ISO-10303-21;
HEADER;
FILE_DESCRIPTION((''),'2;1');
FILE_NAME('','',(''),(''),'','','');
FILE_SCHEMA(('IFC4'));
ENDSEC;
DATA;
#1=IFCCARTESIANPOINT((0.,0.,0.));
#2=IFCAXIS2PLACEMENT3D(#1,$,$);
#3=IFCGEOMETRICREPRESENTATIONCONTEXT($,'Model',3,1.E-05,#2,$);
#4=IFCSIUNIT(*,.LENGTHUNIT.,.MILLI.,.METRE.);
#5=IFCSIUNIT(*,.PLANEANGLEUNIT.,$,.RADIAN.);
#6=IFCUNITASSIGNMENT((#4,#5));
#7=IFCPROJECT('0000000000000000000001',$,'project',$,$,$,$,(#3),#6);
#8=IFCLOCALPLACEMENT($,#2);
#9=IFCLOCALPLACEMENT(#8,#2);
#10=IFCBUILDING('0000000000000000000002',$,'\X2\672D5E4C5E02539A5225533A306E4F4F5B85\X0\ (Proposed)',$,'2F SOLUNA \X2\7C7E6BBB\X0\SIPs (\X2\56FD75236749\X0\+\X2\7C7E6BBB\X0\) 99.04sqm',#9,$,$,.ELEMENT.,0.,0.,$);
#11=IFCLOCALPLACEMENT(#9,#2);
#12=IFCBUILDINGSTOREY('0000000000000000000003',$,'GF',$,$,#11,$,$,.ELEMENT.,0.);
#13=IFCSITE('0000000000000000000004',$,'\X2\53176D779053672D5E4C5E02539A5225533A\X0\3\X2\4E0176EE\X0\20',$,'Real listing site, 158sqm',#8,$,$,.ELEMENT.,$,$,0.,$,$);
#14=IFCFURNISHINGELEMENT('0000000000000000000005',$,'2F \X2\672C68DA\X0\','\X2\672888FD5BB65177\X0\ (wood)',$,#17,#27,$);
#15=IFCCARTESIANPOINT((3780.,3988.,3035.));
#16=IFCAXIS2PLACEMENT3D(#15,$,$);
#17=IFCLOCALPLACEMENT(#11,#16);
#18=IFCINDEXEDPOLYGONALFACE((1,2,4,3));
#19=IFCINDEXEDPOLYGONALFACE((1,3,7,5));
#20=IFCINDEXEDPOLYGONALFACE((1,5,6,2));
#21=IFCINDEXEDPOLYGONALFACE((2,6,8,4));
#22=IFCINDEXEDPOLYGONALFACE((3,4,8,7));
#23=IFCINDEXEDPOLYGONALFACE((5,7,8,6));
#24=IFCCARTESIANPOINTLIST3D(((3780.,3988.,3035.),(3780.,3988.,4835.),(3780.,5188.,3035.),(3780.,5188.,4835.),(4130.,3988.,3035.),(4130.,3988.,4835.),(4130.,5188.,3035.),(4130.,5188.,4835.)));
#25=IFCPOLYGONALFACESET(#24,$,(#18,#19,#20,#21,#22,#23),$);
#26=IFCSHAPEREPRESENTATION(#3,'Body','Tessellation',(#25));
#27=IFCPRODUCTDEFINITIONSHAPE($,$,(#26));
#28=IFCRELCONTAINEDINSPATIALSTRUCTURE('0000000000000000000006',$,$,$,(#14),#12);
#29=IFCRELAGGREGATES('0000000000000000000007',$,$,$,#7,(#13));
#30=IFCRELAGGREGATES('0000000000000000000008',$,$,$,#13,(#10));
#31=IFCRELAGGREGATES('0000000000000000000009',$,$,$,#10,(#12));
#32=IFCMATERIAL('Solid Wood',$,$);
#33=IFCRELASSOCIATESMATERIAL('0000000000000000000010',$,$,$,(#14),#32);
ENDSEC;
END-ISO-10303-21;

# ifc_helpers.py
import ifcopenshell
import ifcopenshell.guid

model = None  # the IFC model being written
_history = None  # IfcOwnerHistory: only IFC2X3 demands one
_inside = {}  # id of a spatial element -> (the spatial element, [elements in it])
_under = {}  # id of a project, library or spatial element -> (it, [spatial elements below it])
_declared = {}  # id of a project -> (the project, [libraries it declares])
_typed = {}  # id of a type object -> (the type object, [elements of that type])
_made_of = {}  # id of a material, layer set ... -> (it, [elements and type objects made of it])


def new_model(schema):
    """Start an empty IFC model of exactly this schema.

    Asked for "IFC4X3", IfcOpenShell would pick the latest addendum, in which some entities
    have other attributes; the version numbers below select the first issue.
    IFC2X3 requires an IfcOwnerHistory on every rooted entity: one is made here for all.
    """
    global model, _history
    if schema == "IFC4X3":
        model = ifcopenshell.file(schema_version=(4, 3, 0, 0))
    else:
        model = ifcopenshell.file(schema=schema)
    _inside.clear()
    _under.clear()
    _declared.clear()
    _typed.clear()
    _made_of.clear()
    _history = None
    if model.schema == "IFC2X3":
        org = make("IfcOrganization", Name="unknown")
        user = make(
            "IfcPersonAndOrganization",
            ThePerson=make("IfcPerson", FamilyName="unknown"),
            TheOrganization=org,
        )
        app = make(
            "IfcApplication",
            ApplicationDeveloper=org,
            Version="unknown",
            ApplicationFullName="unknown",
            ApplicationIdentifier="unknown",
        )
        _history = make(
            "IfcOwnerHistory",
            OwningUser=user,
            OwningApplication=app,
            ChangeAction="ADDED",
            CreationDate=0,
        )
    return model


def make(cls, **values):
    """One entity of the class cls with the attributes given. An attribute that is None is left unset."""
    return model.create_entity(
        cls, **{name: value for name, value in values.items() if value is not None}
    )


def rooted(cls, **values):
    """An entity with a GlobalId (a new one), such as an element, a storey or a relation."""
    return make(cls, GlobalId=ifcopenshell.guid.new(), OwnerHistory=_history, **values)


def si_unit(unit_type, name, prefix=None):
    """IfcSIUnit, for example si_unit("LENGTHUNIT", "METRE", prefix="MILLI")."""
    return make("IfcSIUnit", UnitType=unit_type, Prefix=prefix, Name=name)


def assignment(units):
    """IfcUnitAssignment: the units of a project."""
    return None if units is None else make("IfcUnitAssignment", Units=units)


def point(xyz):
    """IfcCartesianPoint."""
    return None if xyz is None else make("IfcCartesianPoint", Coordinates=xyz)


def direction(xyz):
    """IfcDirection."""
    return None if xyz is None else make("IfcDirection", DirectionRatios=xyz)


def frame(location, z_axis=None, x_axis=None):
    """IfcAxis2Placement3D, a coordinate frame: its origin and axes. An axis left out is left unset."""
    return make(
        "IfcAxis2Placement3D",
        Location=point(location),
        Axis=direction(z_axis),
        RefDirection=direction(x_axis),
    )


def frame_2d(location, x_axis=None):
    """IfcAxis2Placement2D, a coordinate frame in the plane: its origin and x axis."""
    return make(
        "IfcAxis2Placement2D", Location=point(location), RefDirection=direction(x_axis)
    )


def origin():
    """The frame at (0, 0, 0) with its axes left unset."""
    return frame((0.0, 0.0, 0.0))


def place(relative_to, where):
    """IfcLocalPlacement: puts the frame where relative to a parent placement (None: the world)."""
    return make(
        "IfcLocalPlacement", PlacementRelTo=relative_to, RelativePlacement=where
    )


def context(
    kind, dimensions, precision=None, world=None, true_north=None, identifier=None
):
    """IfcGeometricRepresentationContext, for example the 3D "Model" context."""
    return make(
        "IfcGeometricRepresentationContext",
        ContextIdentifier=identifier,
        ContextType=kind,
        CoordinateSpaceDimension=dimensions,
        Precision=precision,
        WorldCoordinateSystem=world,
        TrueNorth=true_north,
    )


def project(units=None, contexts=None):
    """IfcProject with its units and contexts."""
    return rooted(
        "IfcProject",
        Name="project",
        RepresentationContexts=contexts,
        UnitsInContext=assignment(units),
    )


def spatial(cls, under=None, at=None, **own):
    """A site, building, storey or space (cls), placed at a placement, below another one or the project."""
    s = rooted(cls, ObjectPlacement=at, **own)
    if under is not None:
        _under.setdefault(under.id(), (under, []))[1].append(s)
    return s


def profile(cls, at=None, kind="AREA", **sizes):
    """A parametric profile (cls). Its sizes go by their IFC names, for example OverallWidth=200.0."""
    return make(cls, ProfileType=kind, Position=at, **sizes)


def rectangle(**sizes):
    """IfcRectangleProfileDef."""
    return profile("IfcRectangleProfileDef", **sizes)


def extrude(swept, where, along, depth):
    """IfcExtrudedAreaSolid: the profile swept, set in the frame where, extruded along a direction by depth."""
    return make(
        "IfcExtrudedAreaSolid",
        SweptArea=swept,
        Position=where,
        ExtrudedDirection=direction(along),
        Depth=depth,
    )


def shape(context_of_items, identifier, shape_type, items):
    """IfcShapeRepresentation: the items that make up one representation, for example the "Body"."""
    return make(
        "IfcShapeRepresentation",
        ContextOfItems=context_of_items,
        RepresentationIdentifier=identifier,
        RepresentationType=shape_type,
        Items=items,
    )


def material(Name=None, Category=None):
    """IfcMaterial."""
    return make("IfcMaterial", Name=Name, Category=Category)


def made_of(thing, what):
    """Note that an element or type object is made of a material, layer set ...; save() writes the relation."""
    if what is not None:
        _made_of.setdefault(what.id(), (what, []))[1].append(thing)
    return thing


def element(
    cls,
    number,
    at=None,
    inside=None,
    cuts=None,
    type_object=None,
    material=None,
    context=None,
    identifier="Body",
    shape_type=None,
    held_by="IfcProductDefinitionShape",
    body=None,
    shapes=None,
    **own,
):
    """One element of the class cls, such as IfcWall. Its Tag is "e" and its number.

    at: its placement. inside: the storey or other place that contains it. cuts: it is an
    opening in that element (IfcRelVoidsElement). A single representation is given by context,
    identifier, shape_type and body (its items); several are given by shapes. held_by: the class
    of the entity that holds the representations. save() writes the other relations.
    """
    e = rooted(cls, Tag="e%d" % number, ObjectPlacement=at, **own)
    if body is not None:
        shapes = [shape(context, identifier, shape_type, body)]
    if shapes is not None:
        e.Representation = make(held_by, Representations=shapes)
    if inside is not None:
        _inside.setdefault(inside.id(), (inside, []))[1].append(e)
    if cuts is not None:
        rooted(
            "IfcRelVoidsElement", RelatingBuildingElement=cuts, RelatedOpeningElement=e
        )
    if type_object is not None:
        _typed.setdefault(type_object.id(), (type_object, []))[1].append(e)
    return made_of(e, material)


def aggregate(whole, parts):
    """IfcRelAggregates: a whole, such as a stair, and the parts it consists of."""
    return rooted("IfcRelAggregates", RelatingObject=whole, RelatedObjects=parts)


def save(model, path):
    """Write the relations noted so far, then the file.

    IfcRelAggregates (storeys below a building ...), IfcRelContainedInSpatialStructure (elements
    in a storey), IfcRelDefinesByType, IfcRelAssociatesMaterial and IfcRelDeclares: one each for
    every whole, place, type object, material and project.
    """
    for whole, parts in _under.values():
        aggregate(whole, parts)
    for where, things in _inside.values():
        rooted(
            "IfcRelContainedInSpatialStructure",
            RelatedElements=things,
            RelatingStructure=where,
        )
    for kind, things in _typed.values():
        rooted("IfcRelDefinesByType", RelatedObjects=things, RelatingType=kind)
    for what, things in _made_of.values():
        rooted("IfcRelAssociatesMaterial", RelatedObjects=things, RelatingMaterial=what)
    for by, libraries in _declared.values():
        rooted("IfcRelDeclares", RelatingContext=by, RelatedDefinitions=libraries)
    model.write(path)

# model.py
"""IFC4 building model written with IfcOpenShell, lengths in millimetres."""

from ifc_helpers import new_model, si_unit, frame, frame_2d, origin, place, context, project, spatial, rectangle, extrude, material, element, save


model = new_model("IFC4")

# Units and contexts
model_context = context("Model", 3, precision=1e-05, world=origin())
ifc_project = project(units=[si_unit("LENGTHUNIT", "METRE", prefix="MILLI"), si_unit("PLANEANGLEUNIT", "RADIAN")], contexts=[model_context])

# Site, building, storey
site_placement = place(None, origin())
site = spatial("IfcSite", under=ifc_project, at=site_placement, Name="北海道札幌市厚別区3丁目20", ObjectType="Real listing site, 158sqm", CompositionType="ELEMENT", RefElevation=0.0)
building_placement = place(site_placement, origin())
building = spatial("IfcBuilding", under=site, at=building_placement, Name="札幌市厚別区の住宅 (Proposed)", ObjectType="2F SOLUNA 籾殻SIPs (国産杉+籾殻) 99.04sqm", CompositionType="ELEMENT", ElevationOfRefHeight=0.0, ElevationOfTerrain=0.0)
storey_placement = place(building_placement, origin())
storey = spatial("IfcBuildingStorey", under=building, at=storey_placement, Name="GF", CompositionType="ELEMENT", Elevation=0.0)

# Shared definitions
ifc_material_1 = material(Name="Solid Wood")

# Furnishing element
furnishing_placement = place(storey_placement, frame((3780.0, 3988.0, 3035.0)))
element("IfcFurnishingElement", 1, at=furnishing_placement, inside=storey, material=ifc_material_1, Name="2F 本棚", Description="木製家具 (wood)", context=model_context, shape_type="SweptSolid", body=[
    extrude(rectangle(XDim=350.0, YDim=1200.0, at=frame_2d((175.0, 600.0))), frame((3780.0, 3988.0, 3035.0)), (0.0, 0.0, 1.0), 1800.0),
])

save(model, "model.ifc")
